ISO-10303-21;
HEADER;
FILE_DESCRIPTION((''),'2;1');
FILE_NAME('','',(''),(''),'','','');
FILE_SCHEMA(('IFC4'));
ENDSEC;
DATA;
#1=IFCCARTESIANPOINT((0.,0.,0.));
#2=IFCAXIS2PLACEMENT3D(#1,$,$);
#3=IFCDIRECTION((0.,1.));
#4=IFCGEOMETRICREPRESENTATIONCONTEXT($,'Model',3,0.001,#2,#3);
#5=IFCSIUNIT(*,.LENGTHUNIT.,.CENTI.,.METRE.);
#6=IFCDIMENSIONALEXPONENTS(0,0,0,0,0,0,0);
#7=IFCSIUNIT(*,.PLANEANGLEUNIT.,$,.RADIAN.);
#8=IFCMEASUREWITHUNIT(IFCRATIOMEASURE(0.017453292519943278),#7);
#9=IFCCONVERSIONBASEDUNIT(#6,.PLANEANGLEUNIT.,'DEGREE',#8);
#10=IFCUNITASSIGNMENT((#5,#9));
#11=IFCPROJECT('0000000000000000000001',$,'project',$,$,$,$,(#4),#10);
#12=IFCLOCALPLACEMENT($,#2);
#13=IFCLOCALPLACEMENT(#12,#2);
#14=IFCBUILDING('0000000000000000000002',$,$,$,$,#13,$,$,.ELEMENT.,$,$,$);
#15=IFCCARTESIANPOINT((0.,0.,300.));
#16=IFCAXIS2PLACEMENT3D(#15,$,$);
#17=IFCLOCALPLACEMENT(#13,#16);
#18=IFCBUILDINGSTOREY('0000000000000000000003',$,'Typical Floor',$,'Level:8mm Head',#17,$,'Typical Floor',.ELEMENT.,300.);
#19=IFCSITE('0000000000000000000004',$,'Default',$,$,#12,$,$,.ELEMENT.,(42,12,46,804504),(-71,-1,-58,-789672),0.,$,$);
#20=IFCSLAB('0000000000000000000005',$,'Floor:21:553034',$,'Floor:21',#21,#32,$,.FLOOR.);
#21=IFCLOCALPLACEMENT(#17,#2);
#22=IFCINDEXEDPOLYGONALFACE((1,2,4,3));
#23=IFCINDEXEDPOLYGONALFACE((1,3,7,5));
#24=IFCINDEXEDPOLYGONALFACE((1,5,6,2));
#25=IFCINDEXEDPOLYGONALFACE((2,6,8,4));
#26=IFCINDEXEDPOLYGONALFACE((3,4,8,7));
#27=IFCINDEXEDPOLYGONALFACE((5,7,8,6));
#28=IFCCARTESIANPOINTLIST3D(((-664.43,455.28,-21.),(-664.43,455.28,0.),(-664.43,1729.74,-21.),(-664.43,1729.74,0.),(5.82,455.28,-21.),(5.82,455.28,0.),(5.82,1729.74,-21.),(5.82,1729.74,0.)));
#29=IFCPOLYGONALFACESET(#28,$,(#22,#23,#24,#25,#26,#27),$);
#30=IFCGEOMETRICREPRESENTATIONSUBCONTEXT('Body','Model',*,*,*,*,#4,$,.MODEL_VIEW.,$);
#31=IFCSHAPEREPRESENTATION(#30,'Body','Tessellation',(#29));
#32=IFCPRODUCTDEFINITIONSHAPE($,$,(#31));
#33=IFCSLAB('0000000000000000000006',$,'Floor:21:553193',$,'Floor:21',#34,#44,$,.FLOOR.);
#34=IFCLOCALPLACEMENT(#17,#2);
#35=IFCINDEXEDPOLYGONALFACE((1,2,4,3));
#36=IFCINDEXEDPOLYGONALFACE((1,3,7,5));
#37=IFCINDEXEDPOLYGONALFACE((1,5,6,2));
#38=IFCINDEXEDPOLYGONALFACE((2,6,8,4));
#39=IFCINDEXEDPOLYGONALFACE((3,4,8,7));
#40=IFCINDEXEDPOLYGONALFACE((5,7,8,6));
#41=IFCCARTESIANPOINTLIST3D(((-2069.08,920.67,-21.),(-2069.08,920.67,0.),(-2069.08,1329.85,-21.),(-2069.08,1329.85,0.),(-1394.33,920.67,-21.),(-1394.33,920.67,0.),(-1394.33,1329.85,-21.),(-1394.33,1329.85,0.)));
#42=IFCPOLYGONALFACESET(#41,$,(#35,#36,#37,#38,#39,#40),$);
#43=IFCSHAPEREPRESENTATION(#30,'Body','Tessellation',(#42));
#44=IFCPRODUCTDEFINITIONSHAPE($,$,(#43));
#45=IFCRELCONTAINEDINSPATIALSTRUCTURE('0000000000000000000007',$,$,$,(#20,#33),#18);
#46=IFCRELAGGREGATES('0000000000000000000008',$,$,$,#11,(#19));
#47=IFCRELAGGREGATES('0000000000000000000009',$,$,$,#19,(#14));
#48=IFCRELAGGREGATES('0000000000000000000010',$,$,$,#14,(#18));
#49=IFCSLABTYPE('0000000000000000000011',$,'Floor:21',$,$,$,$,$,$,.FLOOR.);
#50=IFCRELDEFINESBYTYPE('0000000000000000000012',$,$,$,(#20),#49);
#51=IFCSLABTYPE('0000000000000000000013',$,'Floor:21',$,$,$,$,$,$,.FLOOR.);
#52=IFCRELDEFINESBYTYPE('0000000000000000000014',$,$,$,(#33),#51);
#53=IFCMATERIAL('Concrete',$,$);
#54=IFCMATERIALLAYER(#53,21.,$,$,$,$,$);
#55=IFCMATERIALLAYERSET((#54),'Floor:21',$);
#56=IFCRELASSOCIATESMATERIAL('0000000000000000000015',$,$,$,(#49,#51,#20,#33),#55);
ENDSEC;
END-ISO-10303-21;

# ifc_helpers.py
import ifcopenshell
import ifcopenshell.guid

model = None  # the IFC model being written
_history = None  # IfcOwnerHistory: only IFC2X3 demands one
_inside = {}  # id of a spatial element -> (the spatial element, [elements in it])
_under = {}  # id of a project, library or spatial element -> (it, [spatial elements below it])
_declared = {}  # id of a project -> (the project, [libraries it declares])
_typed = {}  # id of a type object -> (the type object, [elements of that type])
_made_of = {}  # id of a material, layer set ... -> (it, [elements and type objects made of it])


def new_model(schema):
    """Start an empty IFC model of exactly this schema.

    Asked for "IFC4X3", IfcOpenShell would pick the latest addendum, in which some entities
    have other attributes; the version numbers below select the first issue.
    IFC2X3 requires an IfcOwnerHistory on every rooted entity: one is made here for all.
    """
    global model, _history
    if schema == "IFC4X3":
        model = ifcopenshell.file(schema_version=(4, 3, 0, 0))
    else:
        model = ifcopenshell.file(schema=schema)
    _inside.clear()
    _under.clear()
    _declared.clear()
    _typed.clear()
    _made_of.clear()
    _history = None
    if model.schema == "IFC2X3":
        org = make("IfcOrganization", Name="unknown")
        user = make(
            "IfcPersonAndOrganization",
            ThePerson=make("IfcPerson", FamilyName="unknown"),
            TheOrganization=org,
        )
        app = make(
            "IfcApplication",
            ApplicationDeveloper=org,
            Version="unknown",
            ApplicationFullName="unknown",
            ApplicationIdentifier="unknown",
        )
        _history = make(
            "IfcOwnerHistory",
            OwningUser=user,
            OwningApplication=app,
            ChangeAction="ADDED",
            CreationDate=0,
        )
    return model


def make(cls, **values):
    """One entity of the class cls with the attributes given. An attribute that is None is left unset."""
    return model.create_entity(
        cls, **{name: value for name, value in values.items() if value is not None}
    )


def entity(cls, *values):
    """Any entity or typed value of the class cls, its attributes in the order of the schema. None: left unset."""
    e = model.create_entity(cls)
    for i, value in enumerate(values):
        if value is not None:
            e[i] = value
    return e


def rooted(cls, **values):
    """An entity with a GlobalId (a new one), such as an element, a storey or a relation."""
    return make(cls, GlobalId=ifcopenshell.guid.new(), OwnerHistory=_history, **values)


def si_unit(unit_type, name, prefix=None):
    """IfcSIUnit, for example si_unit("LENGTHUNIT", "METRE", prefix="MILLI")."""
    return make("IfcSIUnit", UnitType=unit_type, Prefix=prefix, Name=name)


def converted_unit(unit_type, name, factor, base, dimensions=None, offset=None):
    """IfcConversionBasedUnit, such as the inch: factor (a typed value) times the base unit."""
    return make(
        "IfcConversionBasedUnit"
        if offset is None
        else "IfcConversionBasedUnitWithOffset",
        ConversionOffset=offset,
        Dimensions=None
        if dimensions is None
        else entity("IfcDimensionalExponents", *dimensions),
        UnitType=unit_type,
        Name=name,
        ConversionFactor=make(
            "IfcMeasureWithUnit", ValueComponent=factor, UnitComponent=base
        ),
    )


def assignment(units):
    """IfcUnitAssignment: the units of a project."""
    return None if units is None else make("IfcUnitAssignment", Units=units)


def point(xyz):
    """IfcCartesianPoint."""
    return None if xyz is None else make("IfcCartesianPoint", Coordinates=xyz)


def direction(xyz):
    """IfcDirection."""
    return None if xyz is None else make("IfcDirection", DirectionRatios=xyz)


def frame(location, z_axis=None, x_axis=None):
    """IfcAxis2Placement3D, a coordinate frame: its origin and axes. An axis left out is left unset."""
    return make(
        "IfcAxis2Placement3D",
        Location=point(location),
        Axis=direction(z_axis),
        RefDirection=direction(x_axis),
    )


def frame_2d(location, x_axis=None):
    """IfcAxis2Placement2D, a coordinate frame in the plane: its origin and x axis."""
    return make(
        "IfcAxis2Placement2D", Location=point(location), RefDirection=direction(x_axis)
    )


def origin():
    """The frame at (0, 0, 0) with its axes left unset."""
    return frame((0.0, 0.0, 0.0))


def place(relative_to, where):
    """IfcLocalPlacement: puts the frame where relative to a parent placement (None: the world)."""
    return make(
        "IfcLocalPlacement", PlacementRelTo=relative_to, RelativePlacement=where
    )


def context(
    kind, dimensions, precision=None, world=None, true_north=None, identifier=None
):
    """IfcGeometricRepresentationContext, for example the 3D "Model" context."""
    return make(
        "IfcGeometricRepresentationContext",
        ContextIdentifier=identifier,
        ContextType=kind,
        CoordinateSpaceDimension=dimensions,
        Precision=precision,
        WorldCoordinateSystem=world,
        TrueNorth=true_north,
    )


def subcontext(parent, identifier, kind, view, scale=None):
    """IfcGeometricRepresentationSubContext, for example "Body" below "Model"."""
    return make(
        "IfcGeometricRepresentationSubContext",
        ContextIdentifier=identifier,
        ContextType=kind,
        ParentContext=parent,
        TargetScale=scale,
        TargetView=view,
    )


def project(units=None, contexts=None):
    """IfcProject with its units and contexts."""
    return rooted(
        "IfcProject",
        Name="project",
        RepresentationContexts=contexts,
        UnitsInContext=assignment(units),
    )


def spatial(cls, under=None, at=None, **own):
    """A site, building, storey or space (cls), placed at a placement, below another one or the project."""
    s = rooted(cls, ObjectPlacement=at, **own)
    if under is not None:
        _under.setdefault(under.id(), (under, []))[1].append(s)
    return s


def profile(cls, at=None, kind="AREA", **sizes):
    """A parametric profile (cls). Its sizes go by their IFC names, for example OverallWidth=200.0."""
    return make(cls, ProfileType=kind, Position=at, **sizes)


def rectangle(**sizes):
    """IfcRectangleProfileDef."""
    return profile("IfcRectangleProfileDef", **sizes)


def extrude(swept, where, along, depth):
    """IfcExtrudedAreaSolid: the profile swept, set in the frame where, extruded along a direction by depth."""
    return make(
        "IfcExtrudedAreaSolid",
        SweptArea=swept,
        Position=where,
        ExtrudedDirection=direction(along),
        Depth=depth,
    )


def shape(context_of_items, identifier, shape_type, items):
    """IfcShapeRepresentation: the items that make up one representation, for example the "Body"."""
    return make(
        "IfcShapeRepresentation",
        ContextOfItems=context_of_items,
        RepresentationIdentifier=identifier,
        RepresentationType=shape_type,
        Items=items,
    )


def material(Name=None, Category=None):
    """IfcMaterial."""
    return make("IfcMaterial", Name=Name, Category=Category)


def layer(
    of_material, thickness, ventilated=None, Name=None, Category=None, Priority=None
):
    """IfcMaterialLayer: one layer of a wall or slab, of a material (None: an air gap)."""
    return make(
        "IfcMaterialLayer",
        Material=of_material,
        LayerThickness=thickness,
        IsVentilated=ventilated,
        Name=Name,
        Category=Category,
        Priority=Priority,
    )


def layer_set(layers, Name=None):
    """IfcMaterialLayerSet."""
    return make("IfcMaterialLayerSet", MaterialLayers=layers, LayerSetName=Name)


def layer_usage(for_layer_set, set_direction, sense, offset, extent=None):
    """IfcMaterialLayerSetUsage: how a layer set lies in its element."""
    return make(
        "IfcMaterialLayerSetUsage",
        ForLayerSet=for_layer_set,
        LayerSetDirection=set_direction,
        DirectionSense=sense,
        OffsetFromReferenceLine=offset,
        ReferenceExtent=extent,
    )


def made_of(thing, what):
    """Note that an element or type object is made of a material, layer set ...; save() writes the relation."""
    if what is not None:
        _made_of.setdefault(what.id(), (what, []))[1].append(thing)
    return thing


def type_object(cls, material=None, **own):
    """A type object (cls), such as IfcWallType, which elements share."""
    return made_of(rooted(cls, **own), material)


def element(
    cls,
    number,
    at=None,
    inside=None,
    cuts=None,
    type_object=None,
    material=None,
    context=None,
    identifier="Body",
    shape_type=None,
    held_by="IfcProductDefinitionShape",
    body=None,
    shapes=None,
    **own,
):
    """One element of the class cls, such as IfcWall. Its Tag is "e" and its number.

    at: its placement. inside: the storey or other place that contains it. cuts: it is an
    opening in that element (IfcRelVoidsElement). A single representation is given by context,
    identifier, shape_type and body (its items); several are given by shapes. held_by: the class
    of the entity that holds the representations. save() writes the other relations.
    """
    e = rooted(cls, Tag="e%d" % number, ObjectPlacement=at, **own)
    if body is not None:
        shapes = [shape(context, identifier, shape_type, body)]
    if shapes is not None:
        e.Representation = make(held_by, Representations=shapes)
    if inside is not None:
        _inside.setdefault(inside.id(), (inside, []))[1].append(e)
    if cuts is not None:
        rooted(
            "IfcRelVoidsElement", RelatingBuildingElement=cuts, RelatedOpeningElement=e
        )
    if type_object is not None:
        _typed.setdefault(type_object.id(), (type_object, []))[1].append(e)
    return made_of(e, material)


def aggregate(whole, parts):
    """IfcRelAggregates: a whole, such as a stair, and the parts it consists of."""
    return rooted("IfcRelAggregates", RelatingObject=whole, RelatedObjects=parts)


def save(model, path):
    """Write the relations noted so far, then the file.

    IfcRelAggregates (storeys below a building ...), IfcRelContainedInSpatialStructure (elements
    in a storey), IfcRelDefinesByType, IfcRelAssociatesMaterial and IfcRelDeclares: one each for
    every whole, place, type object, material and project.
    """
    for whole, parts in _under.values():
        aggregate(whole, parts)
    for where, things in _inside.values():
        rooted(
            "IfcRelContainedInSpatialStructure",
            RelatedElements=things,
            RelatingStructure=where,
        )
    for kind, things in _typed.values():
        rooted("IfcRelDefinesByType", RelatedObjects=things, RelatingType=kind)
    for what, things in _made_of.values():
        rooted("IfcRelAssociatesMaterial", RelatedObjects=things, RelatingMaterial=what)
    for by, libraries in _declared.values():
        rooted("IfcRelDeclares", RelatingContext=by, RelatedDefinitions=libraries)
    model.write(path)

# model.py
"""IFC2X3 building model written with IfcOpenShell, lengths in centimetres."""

from ifc_helpers import new_model, entity, si_unit, converted_unit, direction, frame, frame_2d, origin, place, context, subcontext, project, spatial, rectangle, extrude, material, layer, layer_set, layer_usage, type_object, element, save


model = new_model("IFC2X3")

# Units and contexts
model_context = context("Model", 3, precision=0.001, world=origin(), true_north=direction((0.0, 1.0)))
body_context = subcontext(model_context, "Body", "Model", "MODEL_VIEW")
ifc_project = project(units=[si_unit("LENGTHUNIT", "METRE", prefix="CENTI"), converted_unit("PLANEANGLEUNIT", "DEGREE", entity("IfcRatioMeasure", 0.017453292519943278), si_unit("PLANEANGLEUNIT", "RADIAN"), dimensions=[0, 0, 0, 0, 0, 0, 0])], contexts=[model_context])

# Site, building, storey
site_placement = place(None, origin())
site = spatial("IfcSite", under=ifc_project, at=site_placement, Name="Default", CompositionType="ELEMENT", RefLatitude=(42, 12, 46, 804504), RefLongitude=(-71, -1, -58, -789672), RefElevation=0.0)
building_placement = place(site_placement, origin())
building = spatial("IfcBuilding", under=site, at=building_placement, CompositionType="ELEMENT")
storey_placement = place(building_placement, frame((0.0, 0.0, 300.0)))
storey = spatial("IfcBuildingStorey", under=building, at=storey_placement, Name="Typical Floor", ObjectType="Level:8mm Head", LongName="Typical Floor", CompositionType="ELEMENT", Elevation=300.0)

# Shared definitions
ifc_material = material(Name="Concrete")

# Slabs
ifc_layer = layer(ifc_material, 21.0)
ifc_layer_set = layer_set([ifc_layer], Name="Floor:21")
ifc_layer_usage_1 = layer_usage(ifc_layer_set, "AXIS3", "POSITIVE", 0.0)
slab_type_1 = type_object("IfcSlabType", Name="Floor:21", PredefinedType="FLOOR", material=ifc_layer_set)
slab_1_placement = place(storey_placement, origin())
element("IfcSlab", 1, at=slab_1_placement, inside=storey, type_object=slab_type_1, material=ifc_layer_usage_1, Name="Floor:21:553034", ObjectType="Floor:21", PredefinedType="FLOOR", context=body_context, shape_type="SweptSolid", body=[
    extrude(rectangle(XDim=1274.46, YDim=670.26, at=frame_2d((0.0, 0.0), x_axis=(1.0, 0.0))), frame((-329.31, 1092.51, 0.0), z_axis=(0.0, 0.0, -1.0), x_axis=(0.0, 1.0, 0.0)), (0.0, 0.0, 1.0), 21.0),
])
ifc_layer_usage_2 = layer_usage(ifc_layer_set, "AXIS3", "POSITIVE", 0.0)
slab_type_2 = type_object("IfcSlabType", Name="Floor:21", PredefinedType="FLOOR", material=ifc_layer_set)
slab_2_placement = place(storey_placement, origin())
element("IfcSlab", 2, at=slab_2_placement, inside=storey, type_object=slab_type_2, material=ifc_layer_usage_2, Name="Floor:21:553193", ObjectType="Floor:21", PredefinedType="FLOOR", context=body_context, shape_type="SweptSolid", body=[
    extrude(rectangle(XDim=409.18, YDim=674.75, at=frame_2d((0.0, 0.0), x_axis=(1.0, 0.0))), frame((-1731.7, 1125.26, 0.0), z_axis=(0.0, 0.0, -1.0), x_axis=(0.0, 1.0, 0.0)), (0.0, 0.0, 1.0), 21.0),
])

save(model, "model.ifc")
